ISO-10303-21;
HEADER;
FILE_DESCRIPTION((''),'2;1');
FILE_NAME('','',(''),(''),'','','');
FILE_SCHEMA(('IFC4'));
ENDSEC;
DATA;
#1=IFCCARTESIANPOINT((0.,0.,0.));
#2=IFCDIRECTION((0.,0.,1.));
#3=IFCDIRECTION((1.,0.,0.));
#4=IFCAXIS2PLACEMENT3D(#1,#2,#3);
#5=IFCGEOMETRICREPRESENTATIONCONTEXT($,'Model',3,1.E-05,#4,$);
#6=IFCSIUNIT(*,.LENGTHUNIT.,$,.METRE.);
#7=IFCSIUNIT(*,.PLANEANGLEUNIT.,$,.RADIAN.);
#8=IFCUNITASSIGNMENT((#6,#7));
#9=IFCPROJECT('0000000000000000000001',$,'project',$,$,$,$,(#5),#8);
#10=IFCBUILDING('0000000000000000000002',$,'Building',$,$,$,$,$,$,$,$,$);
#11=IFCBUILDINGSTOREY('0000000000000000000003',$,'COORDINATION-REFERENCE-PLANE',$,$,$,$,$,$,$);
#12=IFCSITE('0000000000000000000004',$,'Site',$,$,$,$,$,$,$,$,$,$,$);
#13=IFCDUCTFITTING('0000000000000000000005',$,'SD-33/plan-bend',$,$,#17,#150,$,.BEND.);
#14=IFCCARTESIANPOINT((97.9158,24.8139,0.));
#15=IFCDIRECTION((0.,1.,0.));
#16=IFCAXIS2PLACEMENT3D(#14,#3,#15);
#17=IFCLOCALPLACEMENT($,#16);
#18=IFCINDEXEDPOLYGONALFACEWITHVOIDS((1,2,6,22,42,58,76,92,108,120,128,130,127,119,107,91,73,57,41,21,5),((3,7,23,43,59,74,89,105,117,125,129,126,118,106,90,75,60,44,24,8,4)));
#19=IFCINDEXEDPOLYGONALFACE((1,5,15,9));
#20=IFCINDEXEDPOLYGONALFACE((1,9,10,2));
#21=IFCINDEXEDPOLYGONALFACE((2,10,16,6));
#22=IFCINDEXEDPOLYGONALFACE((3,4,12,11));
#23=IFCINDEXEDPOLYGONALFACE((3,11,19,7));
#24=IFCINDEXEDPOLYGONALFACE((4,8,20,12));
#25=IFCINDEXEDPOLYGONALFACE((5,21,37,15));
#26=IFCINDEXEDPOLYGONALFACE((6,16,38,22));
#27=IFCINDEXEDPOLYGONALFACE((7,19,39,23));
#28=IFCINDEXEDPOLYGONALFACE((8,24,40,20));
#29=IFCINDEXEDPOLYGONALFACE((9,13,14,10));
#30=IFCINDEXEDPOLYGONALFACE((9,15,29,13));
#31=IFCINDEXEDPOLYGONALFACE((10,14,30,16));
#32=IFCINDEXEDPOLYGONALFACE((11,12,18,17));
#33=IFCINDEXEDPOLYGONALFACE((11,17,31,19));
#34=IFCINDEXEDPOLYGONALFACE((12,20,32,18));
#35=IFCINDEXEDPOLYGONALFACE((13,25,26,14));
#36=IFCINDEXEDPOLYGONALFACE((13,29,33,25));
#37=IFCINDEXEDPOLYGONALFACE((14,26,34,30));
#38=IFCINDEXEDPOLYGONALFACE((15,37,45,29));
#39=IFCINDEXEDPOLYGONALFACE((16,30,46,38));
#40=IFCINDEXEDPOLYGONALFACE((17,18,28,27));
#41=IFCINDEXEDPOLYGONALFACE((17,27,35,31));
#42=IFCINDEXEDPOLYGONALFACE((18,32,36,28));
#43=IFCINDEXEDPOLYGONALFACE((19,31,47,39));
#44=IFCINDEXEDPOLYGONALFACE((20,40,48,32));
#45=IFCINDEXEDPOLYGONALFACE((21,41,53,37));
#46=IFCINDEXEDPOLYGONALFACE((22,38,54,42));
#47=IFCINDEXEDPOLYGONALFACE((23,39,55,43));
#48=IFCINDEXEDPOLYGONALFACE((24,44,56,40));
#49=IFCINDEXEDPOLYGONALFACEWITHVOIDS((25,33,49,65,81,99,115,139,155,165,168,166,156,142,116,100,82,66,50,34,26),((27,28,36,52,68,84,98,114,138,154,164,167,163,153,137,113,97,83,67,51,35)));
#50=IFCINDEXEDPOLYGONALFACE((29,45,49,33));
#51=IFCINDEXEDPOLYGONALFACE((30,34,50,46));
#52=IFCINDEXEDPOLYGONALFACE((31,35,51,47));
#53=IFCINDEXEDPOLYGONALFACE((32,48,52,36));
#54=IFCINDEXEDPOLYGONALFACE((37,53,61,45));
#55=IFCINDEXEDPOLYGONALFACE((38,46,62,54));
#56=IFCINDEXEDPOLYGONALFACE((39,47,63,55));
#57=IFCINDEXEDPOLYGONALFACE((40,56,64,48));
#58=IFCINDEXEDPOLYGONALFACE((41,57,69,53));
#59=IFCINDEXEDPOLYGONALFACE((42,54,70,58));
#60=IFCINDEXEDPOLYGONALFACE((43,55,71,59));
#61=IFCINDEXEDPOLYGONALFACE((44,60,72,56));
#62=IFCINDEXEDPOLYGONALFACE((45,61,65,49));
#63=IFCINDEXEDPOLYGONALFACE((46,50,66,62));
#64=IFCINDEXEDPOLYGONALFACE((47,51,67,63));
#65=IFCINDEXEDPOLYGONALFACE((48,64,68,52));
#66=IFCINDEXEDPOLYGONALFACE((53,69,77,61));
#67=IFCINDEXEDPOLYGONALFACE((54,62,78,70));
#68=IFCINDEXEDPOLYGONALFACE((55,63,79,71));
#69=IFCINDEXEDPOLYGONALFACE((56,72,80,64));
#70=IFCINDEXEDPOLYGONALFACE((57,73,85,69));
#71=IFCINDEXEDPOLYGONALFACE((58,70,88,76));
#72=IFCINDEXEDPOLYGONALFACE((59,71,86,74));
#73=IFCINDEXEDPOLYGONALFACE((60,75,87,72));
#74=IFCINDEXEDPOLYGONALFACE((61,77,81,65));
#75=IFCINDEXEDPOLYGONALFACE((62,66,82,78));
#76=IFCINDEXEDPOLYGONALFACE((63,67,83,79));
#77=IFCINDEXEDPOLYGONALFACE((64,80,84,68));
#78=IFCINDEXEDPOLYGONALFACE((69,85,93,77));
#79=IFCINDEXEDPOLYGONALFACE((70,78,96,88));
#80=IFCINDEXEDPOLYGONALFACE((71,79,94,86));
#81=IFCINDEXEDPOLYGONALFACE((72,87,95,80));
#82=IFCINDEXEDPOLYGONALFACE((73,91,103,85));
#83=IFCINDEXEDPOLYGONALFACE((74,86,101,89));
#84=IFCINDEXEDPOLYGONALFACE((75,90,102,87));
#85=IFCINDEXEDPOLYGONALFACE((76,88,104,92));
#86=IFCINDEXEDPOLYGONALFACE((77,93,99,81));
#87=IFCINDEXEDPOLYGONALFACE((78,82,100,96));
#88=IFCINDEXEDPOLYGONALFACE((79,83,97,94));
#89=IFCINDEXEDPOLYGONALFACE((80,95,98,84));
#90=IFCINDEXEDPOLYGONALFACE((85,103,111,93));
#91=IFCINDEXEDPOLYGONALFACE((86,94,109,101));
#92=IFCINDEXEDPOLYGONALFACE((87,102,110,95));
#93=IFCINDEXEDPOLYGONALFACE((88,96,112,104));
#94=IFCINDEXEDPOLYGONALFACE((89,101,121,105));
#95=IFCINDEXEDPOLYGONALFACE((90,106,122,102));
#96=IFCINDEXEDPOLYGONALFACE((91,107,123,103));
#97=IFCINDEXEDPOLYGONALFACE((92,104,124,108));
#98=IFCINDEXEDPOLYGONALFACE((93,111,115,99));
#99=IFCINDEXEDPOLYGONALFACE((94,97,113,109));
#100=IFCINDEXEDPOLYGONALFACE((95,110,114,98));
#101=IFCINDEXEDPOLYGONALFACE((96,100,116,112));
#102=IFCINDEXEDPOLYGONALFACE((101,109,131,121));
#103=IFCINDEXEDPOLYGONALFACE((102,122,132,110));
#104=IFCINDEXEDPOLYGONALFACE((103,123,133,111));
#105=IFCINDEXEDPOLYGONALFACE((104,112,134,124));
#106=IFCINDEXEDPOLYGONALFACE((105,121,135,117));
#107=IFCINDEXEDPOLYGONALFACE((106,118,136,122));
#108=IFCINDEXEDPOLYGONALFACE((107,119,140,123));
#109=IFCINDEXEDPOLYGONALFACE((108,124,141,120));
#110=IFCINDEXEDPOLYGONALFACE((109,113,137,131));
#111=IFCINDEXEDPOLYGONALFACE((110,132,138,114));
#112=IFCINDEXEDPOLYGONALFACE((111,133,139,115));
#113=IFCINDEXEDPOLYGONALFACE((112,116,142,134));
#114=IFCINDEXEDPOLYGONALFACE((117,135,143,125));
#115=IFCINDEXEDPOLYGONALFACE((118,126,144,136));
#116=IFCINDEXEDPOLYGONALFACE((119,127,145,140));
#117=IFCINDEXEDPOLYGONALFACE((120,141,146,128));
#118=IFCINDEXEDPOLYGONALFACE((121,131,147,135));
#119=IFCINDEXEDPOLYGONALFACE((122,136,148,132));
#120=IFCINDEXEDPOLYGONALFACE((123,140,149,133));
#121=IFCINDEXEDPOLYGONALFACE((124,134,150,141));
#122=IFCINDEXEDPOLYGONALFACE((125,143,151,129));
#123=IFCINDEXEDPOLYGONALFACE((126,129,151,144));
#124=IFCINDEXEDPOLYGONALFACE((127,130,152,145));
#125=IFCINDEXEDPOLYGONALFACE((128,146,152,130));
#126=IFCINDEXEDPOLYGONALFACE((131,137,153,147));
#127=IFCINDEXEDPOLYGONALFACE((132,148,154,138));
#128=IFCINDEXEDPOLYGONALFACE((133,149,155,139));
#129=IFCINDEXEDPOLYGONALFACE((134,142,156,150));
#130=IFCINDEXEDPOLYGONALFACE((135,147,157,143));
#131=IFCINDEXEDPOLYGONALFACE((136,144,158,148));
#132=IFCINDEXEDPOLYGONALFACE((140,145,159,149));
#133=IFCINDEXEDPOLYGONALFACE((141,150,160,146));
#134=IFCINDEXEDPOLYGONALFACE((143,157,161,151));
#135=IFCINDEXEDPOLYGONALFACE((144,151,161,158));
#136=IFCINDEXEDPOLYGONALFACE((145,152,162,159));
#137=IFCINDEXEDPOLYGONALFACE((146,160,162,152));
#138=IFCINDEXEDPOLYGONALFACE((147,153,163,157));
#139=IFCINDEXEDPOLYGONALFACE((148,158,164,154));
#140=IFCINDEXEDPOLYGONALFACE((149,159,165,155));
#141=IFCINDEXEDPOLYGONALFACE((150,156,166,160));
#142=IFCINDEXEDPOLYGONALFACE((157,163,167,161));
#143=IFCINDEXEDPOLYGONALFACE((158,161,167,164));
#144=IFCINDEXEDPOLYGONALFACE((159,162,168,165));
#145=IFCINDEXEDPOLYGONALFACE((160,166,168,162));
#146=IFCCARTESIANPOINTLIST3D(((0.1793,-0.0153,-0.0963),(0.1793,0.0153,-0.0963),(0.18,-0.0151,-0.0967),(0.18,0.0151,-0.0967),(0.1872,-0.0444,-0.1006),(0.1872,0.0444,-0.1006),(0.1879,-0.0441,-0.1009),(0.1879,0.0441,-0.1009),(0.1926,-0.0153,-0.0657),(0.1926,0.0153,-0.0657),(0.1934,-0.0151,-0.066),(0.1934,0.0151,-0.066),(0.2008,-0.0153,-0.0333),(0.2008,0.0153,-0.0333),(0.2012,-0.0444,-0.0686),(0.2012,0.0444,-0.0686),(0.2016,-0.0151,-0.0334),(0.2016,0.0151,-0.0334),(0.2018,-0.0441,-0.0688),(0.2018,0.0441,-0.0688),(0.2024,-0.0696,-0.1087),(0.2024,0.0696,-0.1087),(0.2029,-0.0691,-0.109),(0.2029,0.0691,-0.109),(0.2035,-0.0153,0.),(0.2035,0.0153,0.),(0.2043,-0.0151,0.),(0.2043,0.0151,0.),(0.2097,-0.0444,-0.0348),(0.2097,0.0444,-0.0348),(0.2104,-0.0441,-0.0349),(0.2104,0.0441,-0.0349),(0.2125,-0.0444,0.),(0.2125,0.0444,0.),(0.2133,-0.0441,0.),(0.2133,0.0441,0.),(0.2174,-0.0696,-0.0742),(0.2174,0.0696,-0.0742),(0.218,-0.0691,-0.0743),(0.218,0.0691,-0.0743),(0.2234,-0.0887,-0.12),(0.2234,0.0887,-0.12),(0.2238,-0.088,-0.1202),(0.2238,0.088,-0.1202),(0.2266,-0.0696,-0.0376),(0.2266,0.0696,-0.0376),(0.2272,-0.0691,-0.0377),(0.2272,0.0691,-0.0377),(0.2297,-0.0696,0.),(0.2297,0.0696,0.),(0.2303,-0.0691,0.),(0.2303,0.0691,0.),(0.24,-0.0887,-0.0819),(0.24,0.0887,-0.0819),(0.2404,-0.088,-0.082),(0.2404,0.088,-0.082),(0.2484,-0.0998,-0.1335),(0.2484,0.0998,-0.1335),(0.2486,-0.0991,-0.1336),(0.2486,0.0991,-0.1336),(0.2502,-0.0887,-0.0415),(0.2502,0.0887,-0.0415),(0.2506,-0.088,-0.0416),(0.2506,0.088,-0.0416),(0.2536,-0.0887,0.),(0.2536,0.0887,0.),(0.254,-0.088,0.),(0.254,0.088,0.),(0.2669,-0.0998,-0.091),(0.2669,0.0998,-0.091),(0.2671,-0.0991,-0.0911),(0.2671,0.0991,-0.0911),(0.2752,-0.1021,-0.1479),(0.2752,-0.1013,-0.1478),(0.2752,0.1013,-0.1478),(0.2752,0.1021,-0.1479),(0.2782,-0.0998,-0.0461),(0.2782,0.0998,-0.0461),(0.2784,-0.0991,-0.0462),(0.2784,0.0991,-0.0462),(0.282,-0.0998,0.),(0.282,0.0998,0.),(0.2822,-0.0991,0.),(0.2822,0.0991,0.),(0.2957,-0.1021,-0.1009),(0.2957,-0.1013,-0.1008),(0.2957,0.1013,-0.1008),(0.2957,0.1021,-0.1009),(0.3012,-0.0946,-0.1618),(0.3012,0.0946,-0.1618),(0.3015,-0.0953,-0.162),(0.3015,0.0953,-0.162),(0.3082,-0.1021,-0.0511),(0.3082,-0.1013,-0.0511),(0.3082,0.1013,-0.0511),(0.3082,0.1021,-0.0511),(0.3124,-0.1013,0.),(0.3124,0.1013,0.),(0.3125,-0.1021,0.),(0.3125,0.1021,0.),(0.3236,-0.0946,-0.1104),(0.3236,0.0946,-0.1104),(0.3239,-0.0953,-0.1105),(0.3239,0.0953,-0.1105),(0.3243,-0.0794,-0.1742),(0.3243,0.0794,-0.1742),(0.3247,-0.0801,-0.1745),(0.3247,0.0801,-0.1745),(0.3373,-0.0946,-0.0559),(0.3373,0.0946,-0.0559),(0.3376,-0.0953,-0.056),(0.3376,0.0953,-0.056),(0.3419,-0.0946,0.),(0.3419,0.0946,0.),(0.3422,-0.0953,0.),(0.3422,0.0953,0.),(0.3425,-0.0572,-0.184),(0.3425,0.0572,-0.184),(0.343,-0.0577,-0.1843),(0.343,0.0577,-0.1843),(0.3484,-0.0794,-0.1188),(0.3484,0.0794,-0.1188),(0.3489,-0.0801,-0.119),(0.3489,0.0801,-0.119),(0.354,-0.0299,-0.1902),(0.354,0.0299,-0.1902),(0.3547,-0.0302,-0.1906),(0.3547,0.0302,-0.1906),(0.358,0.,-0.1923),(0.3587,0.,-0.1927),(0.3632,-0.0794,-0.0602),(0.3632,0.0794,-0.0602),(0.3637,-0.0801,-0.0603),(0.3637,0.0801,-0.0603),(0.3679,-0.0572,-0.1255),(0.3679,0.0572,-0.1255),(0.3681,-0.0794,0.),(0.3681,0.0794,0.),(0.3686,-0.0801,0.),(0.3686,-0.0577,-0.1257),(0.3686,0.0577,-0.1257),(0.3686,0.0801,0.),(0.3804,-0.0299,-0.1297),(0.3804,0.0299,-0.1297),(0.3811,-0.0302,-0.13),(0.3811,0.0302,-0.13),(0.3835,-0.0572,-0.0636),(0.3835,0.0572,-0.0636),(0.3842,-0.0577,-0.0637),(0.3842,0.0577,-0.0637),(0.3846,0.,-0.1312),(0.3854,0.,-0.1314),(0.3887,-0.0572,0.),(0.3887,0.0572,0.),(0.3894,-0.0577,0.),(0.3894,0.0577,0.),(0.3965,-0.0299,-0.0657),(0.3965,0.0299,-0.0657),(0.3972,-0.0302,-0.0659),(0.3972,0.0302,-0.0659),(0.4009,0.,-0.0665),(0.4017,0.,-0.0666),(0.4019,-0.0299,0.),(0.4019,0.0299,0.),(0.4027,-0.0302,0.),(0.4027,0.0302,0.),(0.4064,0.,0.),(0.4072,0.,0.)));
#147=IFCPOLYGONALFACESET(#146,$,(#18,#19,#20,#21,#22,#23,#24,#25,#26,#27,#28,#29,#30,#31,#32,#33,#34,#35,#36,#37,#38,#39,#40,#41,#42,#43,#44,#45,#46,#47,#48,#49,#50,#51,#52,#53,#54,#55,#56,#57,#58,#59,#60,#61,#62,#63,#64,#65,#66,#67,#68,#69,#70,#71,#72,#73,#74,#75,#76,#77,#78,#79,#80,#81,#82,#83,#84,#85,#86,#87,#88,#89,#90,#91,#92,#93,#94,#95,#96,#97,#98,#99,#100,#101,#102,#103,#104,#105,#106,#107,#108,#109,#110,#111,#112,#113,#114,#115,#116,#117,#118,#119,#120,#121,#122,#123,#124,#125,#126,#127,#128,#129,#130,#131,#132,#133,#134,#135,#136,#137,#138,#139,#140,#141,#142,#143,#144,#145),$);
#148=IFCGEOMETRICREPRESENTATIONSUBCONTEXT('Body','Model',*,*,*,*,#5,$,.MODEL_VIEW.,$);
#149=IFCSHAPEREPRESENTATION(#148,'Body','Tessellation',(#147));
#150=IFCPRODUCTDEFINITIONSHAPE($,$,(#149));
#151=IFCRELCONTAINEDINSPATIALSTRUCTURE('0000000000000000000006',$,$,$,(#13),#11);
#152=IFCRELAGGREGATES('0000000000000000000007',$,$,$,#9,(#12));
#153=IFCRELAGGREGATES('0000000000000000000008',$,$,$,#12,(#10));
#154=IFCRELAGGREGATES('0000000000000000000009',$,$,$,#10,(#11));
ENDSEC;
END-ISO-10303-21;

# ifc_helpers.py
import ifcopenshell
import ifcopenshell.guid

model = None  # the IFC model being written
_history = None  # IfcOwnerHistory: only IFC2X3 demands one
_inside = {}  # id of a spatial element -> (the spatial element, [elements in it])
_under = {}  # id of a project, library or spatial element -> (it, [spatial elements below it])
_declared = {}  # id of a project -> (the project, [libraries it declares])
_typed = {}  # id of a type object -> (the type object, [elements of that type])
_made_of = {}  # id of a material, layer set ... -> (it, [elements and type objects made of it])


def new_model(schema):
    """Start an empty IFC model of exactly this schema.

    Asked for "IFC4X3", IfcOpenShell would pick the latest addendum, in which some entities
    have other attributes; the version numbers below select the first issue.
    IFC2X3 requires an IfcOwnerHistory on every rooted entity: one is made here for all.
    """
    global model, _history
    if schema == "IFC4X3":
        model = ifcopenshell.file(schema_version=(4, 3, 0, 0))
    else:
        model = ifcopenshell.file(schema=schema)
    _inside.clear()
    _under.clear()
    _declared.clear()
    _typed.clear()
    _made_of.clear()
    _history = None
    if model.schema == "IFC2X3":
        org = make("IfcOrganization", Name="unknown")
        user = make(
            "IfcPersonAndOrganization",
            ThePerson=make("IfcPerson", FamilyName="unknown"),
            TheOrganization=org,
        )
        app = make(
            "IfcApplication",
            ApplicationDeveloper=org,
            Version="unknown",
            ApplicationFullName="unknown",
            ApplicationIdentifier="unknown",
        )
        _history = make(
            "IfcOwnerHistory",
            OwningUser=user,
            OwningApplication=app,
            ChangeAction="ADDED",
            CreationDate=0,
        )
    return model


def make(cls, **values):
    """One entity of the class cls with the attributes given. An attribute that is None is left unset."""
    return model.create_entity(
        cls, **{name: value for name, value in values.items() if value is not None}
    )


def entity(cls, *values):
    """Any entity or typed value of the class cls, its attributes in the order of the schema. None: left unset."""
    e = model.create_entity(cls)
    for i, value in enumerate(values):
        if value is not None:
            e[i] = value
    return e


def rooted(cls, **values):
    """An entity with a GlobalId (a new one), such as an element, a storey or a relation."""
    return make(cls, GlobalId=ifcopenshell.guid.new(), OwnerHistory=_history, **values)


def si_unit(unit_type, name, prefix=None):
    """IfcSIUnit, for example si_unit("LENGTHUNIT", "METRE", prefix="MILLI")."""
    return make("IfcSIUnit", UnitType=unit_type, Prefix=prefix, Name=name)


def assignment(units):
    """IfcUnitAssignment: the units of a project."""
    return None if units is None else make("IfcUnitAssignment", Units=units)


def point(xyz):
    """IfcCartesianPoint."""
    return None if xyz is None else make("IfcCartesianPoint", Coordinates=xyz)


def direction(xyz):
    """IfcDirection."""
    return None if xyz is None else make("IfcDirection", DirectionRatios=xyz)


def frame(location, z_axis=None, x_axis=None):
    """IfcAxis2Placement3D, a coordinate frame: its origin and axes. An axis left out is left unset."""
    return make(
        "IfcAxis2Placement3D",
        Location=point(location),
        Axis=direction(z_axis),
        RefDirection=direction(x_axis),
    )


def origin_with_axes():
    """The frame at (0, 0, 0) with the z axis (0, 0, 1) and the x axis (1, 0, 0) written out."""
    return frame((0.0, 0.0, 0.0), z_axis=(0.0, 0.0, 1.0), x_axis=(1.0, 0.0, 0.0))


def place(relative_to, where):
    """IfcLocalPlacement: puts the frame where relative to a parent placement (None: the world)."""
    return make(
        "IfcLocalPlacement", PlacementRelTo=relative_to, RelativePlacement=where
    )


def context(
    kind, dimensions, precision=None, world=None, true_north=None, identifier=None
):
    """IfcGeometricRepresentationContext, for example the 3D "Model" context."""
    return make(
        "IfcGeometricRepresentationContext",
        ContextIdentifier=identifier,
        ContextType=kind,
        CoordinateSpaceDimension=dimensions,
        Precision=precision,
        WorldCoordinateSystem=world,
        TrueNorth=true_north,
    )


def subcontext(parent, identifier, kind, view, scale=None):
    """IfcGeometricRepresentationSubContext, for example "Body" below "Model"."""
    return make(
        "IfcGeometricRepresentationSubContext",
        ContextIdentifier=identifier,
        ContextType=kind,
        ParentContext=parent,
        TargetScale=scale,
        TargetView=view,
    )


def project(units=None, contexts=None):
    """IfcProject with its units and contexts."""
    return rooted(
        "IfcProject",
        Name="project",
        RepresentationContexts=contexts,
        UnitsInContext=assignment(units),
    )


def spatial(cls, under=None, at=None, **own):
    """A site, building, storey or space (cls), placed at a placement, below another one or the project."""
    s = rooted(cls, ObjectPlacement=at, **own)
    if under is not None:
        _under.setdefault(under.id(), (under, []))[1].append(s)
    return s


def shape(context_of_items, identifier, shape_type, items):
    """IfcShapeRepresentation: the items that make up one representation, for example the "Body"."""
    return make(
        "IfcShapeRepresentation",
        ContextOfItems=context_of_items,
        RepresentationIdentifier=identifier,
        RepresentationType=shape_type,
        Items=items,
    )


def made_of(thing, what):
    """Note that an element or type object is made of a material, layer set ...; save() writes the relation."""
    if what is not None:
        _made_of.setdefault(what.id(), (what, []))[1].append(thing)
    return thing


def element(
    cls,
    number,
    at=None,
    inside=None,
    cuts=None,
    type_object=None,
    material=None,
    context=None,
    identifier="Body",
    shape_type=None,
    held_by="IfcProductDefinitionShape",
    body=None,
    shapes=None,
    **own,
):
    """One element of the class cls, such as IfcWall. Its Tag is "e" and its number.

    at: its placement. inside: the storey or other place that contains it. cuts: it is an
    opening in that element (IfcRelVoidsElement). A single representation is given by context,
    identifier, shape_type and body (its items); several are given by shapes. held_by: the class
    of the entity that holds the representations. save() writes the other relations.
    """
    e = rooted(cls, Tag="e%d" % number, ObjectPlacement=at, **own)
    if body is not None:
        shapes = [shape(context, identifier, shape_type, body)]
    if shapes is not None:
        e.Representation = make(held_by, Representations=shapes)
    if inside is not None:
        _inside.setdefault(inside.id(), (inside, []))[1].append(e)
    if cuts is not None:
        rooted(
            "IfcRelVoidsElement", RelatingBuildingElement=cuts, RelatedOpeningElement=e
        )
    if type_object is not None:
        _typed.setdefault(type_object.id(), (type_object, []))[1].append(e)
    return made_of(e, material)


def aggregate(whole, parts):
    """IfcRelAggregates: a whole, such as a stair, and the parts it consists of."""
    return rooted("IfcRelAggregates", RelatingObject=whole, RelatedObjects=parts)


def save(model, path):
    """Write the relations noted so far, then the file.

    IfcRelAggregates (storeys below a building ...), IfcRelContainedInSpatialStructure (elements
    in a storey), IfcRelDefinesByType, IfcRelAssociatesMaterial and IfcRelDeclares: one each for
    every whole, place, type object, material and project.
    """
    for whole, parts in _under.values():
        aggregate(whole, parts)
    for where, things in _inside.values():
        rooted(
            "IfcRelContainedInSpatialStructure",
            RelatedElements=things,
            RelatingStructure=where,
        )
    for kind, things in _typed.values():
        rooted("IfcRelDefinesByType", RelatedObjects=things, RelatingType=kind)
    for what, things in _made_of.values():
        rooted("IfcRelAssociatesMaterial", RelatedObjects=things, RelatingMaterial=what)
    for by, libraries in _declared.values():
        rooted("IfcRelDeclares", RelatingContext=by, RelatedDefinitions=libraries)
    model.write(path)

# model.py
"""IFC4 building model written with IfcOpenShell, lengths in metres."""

from ifc_helpers import new_model, entity, si_unit, frame, origin_with_axes, place, context, subcontext, project, spatial, element, save


model = new_model("IFC4")

# Units and contexts
model_context_1 = context("Model", 3, precision=1e-05, world=origin_with_axes())
body_context_1 = subcontext(model_context_1, "Body", "Model", "MODEL_VIEW")
ifc_project = project(units=[si_unit("LENGTHUNIT", "METRE"), si_unit("PLANEANGLEUNIT", "RADIAN")], contexts=[model_context_1])

# Site, building, storey
site = spatial("IfcSite", under=ifc_project, Name="Site")
building = spatial("IfcBuilding", under=site, Name="Building")
storey = spatial("IfcBuildingStorey", under=building, Name="COORDINATION-REFERENCE-PLANE")

# Duct fitting
duct_fitting_1_placement = place(None, frame((97.9158, 24.8139, 0.0), z_axis=(1.0, 0.0, 0.0), x_axis=(0.0, 1.0, 0.0)))
element("IfcDuctFitting", 1, at=duct_fitting_1_placement, inside=storey, Name="SD-33/plan-bend", PredefinedType="BEND", context=body_context_1, shape_type="SweptSolid", body=[
    entity("IfcRevolvedAreaSolid", entity("IfcCircleHollowProfileDef", "AREA", None, entity("IfcAxis2Placement2D", entity("IfcCartesianPoint", [0.3048, 0.0])), 0.1024, 0.0008), entity("IfcAxis2Placement3D", entity("IfcCartesianPoint", [0.0, 0.0, 0.0]), entity("IfcDirection", [0.0, 0.0, 1.0]), entity("IfcDirection", [1.0, 0.0, 0.0])), entity("IfcAxis1Placement", entity("IfcCartesianPoint", [0.0, 0.0, 0.0]), entity("IfcDirection", [0.0, 1.0, 0.0])), 0.49301),
])

save(model, "model.ifc")
